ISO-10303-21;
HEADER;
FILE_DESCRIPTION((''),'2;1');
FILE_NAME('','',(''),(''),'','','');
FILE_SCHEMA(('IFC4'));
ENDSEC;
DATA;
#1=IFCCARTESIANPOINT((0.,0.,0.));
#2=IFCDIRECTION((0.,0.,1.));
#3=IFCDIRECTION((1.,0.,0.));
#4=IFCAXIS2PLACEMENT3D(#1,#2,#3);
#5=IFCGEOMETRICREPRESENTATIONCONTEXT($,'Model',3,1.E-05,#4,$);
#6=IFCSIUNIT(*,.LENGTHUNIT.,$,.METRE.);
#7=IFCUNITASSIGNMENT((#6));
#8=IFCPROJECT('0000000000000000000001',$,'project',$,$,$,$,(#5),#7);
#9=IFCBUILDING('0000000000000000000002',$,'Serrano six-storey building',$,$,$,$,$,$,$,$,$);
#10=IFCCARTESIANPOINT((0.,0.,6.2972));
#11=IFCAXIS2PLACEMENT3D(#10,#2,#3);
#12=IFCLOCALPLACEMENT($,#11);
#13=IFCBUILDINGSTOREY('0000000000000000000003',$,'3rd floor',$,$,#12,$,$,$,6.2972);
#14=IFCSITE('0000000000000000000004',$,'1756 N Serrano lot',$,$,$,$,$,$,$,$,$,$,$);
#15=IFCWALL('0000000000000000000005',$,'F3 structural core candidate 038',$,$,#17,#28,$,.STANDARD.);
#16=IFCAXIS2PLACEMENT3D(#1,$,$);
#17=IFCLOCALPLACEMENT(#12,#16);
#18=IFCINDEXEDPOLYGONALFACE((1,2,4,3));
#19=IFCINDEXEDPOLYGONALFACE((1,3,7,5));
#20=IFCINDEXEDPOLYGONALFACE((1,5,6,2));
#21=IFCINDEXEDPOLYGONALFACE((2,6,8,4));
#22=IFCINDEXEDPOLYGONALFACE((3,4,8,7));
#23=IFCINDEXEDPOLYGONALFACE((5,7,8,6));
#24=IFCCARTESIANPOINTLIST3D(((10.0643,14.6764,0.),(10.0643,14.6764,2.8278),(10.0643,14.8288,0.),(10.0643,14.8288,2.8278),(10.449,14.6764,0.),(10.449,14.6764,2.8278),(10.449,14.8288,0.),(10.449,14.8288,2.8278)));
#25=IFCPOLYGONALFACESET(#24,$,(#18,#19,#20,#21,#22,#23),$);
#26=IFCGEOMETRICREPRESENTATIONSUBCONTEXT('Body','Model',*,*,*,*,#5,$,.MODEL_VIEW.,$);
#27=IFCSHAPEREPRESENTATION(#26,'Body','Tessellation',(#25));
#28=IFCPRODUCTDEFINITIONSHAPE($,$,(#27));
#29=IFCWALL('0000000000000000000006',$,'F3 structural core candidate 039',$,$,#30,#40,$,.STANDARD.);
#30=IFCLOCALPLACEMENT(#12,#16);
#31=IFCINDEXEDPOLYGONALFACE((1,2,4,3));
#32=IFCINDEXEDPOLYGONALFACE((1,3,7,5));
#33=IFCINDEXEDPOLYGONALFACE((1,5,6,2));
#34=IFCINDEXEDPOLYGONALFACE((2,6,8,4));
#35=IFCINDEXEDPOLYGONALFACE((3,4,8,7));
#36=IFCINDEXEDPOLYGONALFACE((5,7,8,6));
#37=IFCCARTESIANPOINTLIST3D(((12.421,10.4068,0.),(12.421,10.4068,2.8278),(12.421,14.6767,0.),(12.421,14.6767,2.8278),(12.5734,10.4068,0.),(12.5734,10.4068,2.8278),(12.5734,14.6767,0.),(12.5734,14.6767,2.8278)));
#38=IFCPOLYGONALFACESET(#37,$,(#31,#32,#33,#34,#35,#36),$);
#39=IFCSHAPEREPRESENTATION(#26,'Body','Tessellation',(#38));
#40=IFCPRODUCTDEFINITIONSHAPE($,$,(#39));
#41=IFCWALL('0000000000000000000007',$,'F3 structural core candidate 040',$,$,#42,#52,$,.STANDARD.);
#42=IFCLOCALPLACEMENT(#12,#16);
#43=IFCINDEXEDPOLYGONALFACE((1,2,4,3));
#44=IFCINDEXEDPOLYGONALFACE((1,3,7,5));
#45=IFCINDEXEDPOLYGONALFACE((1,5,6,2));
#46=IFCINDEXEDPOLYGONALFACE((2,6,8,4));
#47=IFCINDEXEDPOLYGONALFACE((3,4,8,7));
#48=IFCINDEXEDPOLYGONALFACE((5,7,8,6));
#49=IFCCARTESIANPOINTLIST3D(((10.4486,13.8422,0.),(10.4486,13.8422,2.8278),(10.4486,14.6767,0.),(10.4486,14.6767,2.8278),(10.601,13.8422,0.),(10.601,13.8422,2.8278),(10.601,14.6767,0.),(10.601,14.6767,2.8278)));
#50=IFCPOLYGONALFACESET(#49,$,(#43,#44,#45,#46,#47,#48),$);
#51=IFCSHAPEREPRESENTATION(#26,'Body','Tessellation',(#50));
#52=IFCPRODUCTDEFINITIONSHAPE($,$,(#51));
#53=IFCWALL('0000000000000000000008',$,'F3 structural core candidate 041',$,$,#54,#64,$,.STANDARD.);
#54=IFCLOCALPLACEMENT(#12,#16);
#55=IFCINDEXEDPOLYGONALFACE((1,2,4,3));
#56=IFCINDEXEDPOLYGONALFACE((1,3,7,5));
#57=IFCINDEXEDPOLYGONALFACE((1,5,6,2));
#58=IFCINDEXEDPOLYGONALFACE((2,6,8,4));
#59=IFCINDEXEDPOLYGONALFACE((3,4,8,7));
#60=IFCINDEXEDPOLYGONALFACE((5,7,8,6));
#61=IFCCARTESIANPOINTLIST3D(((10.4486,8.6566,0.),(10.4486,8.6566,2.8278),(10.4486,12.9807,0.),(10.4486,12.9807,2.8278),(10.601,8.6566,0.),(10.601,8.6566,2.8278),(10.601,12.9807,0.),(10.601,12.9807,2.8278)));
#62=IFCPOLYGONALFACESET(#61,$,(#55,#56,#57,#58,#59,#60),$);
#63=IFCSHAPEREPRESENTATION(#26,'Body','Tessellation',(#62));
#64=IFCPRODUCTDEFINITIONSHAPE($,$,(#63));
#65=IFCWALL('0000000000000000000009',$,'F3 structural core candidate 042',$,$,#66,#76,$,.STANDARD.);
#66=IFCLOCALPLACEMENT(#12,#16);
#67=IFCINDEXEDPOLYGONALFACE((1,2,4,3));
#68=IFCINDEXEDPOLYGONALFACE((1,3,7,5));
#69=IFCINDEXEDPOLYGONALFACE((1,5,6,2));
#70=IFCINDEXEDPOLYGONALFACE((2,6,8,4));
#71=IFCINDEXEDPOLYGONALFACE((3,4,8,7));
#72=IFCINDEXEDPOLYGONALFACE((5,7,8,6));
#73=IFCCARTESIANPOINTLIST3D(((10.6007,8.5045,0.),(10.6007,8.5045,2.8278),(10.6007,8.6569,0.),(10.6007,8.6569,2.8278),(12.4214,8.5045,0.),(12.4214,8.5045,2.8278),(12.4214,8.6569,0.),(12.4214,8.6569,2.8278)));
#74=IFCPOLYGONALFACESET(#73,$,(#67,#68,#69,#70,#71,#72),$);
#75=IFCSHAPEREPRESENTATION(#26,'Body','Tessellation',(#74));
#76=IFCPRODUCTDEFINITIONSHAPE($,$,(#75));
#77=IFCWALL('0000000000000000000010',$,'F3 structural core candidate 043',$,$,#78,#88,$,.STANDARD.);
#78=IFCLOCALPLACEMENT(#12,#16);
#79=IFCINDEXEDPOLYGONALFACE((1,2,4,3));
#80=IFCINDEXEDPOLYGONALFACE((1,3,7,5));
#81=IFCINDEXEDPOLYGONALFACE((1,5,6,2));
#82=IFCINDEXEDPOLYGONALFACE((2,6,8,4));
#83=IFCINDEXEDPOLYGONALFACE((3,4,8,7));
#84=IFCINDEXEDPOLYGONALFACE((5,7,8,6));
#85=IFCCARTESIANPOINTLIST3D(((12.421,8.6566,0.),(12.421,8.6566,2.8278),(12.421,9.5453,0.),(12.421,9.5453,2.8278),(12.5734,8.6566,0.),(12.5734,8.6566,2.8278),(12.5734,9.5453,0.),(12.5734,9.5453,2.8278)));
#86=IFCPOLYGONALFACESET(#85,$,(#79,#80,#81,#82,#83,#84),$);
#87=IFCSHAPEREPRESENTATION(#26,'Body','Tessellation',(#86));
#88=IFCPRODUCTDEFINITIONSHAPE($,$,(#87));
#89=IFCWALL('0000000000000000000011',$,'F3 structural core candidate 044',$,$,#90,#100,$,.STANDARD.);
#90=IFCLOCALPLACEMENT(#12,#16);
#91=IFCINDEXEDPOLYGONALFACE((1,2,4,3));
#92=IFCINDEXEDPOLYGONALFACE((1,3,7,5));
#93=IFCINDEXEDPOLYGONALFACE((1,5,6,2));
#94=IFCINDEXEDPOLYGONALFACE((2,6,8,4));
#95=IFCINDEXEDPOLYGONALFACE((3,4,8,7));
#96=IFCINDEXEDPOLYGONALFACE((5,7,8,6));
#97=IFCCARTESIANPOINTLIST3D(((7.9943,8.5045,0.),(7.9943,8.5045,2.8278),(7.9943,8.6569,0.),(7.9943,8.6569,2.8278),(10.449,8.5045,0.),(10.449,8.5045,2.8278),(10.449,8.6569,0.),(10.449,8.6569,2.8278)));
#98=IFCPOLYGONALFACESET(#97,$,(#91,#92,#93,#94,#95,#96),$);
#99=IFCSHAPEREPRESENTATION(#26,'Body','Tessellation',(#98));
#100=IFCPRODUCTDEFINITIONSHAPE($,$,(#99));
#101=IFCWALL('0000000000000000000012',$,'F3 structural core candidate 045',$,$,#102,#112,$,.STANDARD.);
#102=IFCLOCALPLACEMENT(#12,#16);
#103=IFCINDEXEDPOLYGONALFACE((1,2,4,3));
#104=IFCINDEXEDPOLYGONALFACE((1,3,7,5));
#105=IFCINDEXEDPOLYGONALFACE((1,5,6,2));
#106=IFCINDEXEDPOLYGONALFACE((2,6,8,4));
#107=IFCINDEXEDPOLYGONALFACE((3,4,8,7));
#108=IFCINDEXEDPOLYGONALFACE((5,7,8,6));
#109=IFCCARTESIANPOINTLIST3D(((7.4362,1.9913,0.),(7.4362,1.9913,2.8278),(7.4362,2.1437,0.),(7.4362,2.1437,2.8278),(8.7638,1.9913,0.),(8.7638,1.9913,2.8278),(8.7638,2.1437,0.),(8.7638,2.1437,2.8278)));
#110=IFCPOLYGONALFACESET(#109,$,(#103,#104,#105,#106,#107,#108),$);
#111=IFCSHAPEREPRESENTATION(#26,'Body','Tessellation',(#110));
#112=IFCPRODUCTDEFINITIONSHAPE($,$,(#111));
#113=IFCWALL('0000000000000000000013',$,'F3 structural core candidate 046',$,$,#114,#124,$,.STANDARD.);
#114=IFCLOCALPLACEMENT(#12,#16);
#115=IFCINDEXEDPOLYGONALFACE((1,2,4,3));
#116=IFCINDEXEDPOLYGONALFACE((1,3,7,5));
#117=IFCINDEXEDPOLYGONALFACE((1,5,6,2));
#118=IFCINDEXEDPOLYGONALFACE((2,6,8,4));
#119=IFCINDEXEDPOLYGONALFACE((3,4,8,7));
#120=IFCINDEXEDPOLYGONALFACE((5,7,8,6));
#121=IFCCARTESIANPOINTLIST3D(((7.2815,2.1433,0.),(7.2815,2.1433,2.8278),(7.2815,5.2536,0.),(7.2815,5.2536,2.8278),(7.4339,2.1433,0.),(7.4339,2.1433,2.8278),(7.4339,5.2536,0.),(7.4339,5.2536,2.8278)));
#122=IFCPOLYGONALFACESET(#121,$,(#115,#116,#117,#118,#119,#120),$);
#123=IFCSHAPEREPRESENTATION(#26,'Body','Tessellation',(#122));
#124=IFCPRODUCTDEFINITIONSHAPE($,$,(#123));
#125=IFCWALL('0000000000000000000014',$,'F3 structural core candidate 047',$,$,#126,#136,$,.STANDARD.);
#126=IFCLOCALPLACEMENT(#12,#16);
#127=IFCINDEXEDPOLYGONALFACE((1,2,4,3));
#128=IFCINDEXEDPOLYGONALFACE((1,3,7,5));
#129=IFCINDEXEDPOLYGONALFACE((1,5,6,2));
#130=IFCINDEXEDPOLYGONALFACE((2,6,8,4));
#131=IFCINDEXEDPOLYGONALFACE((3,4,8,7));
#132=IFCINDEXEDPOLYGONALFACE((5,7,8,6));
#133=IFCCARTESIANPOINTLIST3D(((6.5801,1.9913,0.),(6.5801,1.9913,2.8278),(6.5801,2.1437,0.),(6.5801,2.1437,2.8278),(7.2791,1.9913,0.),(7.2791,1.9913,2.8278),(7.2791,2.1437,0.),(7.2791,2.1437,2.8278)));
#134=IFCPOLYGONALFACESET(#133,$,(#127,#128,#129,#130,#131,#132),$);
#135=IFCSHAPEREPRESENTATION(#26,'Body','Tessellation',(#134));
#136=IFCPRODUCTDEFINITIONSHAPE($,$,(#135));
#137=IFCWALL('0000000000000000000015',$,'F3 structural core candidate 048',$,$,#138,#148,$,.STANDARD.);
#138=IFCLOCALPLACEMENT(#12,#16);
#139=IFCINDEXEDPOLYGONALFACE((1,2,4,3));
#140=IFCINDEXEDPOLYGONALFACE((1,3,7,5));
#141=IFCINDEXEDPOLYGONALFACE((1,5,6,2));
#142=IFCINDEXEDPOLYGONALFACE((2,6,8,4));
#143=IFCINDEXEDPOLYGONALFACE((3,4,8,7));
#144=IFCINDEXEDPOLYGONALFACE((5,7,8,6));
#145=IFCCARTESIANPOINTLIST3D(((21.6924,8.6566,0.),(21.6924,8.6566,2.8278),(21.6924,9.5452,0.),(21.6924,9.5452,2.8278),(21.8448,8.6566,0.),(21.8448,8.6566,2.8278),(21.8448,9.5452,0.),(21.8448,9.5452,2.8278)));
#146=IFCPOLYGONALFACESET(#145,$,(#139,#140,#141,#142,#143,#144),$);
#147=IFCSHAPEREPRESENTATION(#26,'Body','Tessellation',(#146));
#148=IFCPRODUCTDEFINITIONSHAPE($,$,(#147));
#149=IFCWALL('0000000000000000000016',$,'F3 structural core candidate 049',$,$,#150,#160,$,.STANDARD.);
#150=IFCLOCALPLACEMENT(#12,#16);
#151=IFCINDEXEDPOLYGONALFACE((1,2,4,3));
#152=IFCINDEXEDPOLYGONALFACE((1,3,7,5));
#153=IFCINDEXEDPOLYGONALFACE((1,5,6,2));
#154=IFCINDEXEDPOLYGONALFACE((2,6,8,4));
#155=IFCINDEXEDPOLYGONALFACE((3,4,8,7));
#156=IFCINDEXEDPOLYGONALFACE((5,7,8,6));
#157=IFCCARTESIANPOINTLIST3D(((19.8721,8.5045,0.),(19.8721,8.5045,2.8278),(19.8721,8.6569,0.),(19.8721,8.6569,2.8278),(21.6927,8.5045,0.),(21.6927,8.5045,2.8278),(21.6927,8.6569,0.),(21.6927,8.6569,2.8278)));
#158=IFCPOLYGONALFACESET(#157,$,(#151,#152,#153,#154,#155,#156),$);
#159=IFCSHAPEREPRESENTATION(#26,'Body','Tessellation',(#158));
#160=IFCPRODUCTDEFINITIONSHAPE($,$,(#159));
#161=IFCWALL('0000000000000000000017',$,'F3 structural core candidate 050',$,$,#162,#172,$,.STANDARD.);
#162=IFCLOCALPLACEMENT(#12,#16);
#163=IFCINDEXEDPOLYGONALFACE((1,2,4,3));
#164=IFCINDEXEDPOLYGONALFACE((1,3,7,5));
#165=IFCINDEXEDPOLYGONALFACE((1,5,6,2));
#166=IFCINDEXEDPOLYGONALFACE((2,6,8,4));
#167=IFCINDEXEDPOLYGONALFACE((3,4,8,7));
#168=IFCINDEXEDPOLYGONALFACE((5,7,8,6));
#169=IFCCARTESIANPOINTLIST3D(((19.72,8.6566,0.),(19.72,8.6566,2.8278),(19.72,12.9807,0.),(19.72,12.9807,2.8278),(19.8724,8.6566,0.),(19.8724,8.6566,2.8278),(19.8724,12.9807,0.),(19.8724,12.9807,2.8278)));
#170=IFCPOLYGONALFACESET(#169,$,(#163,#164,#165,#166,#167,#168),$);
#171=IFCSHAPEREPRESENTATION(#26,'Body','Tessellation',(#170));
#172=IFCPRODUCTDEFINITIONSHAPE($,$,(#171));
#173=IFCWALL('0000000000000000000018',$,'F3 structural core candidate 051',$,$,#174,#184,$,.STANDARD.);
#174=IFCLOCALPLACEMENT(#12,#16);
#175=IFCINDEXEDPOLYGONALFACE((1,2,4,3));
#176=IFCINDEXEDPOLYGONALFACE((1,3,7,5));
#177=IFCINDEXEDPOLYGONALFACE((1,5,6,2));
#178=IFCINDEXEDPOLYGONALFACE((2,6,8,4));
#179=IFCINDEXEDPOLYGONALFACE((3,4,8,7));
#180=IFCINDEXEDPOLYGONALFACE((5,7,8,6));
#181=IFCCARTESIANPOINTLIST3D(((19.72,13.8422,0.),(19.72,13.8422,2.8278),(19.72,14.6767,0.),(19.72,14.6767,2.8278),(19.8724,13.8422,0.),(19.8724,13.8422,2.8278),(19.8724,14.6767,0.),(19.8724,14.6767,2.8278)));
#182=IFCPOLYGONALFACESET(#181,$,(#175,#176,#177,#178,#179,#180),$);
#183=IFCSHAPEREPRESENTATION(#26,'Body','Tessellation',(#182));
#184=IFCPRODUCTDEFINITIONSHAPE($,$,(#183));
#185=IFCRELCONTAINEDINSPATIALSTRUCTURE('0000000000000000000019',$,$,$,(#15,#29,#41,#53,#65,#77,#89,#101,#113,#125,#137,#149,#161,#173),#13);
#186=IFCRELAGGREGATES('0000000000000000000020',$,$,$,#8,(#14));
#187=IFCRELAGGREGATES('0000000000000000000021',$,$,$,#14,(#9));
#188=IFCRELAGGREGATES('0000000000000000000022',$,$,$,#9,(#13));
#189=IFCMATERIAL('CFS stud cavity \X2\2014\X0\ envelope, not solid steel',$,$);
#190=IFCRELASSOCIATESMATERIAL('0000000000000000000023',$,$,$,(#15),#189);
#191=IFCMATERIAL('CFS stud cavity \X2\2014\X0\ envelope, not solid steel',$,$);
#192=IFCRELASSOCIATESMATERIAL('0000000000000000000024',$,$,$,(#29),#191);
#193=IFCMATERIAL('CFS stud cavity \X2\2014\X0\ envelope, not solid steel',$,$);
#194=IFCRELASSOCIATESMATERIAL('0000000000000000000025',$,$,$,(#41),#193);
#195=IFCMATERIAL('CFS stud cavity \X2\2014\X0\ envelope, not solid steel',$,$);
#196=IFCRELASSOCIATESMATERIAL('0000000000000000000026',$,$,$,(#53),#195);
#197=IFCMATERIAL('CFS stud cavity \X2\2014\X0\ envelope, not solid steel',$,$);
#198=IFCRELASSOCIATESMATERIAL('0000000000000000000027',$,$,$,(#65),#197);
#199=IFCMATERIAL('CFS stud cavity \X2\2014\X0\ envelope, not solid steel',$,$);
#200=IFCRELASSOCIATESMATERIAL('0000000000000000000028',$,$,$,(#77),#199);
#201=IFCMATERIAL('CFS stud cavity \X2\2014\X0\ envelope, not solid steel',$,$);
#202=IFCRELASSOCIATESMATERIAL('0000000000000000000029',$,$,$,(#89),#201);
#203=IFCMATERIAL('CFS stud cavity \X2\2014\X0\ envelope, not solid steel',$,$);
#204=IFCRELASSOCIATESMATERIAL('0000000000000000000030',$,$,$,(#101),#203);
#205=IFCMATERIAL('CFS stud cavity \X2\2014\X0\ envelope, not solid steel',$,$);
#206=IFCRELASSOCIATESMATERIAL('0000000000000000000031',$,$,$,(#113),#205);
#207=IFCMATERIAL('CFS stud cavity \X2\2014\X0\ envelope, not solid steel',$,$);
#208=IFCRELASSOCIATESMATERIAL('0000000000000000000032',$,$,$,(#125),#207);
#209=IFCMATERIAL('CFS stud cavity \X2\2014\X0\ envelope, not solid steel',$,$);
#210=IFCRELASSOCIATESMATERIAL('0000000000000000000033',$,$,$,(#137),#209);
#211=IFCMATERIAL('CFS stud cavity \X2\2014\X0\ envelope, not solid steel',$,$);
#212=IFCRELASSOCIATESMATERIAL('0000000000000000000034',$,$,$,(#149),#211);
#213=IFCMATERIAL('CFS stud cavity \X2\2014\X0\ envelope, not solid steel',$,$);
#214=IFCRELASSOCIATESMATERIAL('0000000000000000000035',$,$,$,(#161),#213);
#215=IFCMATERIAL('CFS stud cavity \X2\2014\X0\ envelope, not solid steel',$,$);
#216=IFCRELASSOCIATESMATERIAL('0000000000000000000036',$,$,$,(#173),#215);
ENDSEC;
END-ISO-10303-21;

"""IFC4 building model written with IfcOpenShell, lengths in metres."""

from ifc_helpers import new_model, si_unit, frame, origin_with_axes, place, context, subcontext, project, spatial, polyline, outline, extrude, material, element, save


model = new_model("IFC4")

# Units and contexts
model_context = context("Model", 3, precision=1e-05, world=origin_with_axes())
body_context = subcontext(model_context, "Body", "Model", "MODEL_VIEW")
ifc_project = project(units=[si_unit("LENGTHUNIT", "METRE")], contexts=[model_context])

# Site, building, storey
site = spatial("IfcSite", under=ifc_project, Name="1756 N Serrano lot")
building = spatial("IfcBuilding", under=site, Name="Serrano six-storey building")
storey_placement = place(None, frame((0.0, 0.0, 6.2972), z_axis=(0.0, 0.0, 1.0), x_axis=(1.0, 0.0, 0.0)))
storey = spatial("IfcBuildingStorey", under=building, at=storey_placement, Name="3rd floor", Elevation=6.2972)

# Walls
ifc_material_1 = material(Name="CFS stud cavity — envelope, not solid steel")
wall_1_placement = place(storey_placement, frame((0.0, 0.0, -6.2972), z_axis=(0.0, 0.0, 1.0), x_axis=(1.0, 0.0, 0.0)))
element("IfcWall", 1, at=wall_1_placement, inside=storey, material=ifc_material_1, Name="F3 structural core candidate 038", PredefinedType="STANDARD", context=body_context, shape_type="SweptSolid", body=[
    extrude(outline(polyline([(10.449, 14.8288), (10.449, 14.6764), (10.0643, 14.6764), (10.0643, 14.8288), (10.449, 14.8288)])), frame((0.0, 0.0, 6.2972)), (0.0, 0.0, 1.0), 2.8278),
])
ifc_material_2 = material(Name="CFS stud cavity — envelope, not solid steel")
wall_2_placement = place(storey_placement, frame((0.0, 0.0, -6.2972), z_axis=(0.0, 0.0, 1.0), x_axis=(1.0, 0.0, 0.0)))
element("IfcWall", 2, at=wall_2_placement, inside=storey, material=ifc_material_2, Name="F3 structural core candidate 039", PredefinedType="STANDARD", context=body_context, shape_type="SweptSolid", body=[
    extrude(outline(polyline([(12.5734, 10.4068), (12.421, 10.4068), (12.421, 14.6767), (12.5734, 14.6767), (12.5734, 10.4068)])), frame((0.0, 0.0, 6.2972)), (0.0, 0.0, 1.0), 2.8278),
])
ifc_material_3 = material(Name="CFS stud cavity — envelope, not solid steel")
wall_3_placement = place(storey_placement, frame((0.0, 0.0, -6.2972), z_axis=(0.0, 0.0, 1.0), x_axis=(1.0, 0.0, 0.0)))
element("IfcWall", 3, at=wall_3_placement, inside=storey, material=ifc_material_3, Name="F3 structural core candidate 040", PredefinedType="STANDARD", context=body_context, shape_type="SweptSolid", body=[
    extrude(outline(polyline([(10.601, 13.8422), (10.4486, 13.8422), (10.4486, 14.6767), (10.601, 14.6767), (10.601, 13.8422)])), frame((0.0, 0.0, 6.2972)), (0.0, 0.0, 1.0), 2.8278),
])
ifc_material_4 = material(Name="CFS stud cavity — envelope, not solid steel")
wall_4_placement = place(storey_placement, frame((0.0, 0.0, -6.2972), z_axis=(0.0, 0.0, 1.0), x_axis=(1.0, 0.0, 0.0)))
element("IfcWall", 4, at=wall_4_placement, inside=storey, material=ifc_material_4, Name="F3 structural core candidate 041", PredefinedType="STANDARD", context=body_context, shape_type="SweptSolid", body=[
    extrude(outline(polyline([(10.601, 8.6566), (10.4486, 8.6566), (10.4486, 12.9807), (10.601, 12.9807), (10.601, 8.6566)])), frame((0.0, 0.0, 6.2972)), (0.0, 0.0, 1.0), 2.8278),
])
ifc_material_5 = material(Name="CFS stud cavity — envelope, not solid steel")
wall_5_placement = place(storey_placement, frame((0.0, 0.0, -6.2972), z_axis=(0.0, 0.0, 1.0), x_axis=(1.0, 0.0, 0.0)))
element("IfcWall", 5, at=wall_5_placement, inside=storey, material=ifc_material_5, Name="F3 structural core candidate 042", PredefinedType="STANDARD", context=body_context, shape_type="SweptSolid", body=[
    extrude(outline(polyline([(12.4214, 8.6569), (12.4214, 8.5045), (10.6007, 8.5045), (10.6007, 8.6569), (12.4214, 8.6569)])), frame((0.0, 0.0, 6.2972)), (0.0, 0.0, 1.0), 2.8278),
])
ifc_material_6 = material(Name="CFS stud cavity — envelope, not solid steel")
wall_6_placement = place(storey_placement, frame((0.0, 0.0, -6.2972), z_axis=(0.0, 0.0, 1.0), x_axis=(1.0, 0.0, 0.0)))
element("IfcWall", 6, at=wall_6_placement, inside=storey, material=ifc_material_6, Name="F3 structural core candidate 043", PredefinedType="STANDARD", context=body_context, shape_type="SweptSolid", body=[
    extrude(outline(polyline([(12.5734, 8.6566), (12.421, 8.6566), (12.421, 9.5453), (12.5734, 9.5453), (12.5734, 8.6566)])), frame((0.0, 0.0, 6.2972)), (0.0, 0.0, 1.0), 2.8278),
])
ifc_material_7 = material(Name="CFS stud cavity — envelope, not solid steel")
wall_7_placement = place(storey_placement, frame((0.0, 0.0, -6.2972), z_axis=(0.0, 0.0, 1.0), x_axis=(1.0, 0.0, 0.0)))
element("IfcWall", 7, at=wall_7_placement, inside=storey, material=ifc_material_7, Name="F3 structural core candidate 044", PredefinedType="STANDARD", context=body_context, shape_type="SweptSolid", body=[
    extrude(outline(polyline([(10.449, 8.6569), (10.449, 8.5045), (7.9943, 8.5045), (7.9943, 8.6569), (10.449, 8.6569)])), frame((0.0, 0.0, 6.2972)), (0.0, 0.0, 1.0), 2.8278),
])
ifc_material_8 = material(Name="CFS stud cavity — envelope, not solid steel")
wall_8_placement = place(storey_placement, frame((0.0, 0.0, -6.2972), z_axis=(0.0, 0.0, 1.0), x_axis=(1.0, 0.0, 0.0)))
element("IfcWall", 8, at=wall_8_placement, inside=storey, material=ifc_material_8, Name="F3 structural core candidate 045", PredefinedType="STANDARD", context=body_context, shape_type="SweptSolid", body=[
    extrude(outline(polyline([(8.7638, 2.1437), (8.7638, 1.9913), (7.4362, 1.9913), (7.4362, 2.1437), (8.7638, 2.1437)])), frame((0.0, 0.0, 6.2972)), (0.0, 0.0, 1.0), 2.8278),
])
ifc_material_9 = material(Name="CFS stud cavity — envelope, not solid steel")
wall_9_placement = place(storey_placement, frame((0.0, 0.0, -6.2972), z_axis=(0.0, 0.0, 1.0), x_axis=(1.0, 0.0, 0.0)))
element("IfcWall", 9, at=wall_9_placement, inside=storey, material=ifc_material_9, Name="F3 structural core candidate 046", PredefinedType="STANDARD", context=body_context, shape_type="SweptSolid", body=[
    extrude(outline(polyline([(7.4339, 2.1433), (7.2815, 2.1433), (7.2815, 5.2536), (7.4339, 5.2536), (7.4339, 2.1433)])), frame((0.0, 0.0, 6.2972)), (0.0, 0.0, 1.0), 2.8278),
])
ifc_material_10 = material(Name="CFS stud cavity — envelope, not solid steel")
wall_10_placement = place(storey_placement, frame((0.0, 0.0, -6.2972), z_axis=(0.0, 0.0, 1.0), x_axis=(1.0, 0.0, 0.0)))
element("IfcWall", 10, at=wall_10_placement, inside=storey, material=ifc_material_10, Name="F3 structural core candidate 047", PredefinedType="STANDARD", context=body_context, shape_type="SweptSolid", body=[
    extrude(outline(polyline([(7.2791, 2.1437), (7.2791, 1.9913), (6.5801, 1.9913), (6.5801, 2.1437), (7.2791, 2.1437)])), frame((0.0, 0.0, 6.2972)), (0.0, 0.0, 1.0), 2.8278),
])
ifc_material_11 = material(Name="CFS stud cavity — envelope, not solid steel")
wall_11_placement = place(storey_placement, frame((0.0, 0.0, -6.2972), z_axis=(0.0, 0.0, 1.0), x_axis=(1.0, 0.0, 0.0)))
element("IfcWall", 11, at=wall_11_placement, inside=storey, material=ifc_material_11, Name="F3 structural core candidate 048", PredefinedType="STANDARD", context=body_context, shape_type="SweptSolid", body=[
    extrude(outline(polyline([(21.8448, 8.6566), (21.6924, 8.6566), (21.6924, 9.5452), (21.8448, 9.5452), (21.8448, 8.6566)])), frame((0.0, 0.0, 6.2972)), (0.0, 0.0, 1.0), 2.8278),
])
ifc_material_12 = material(Name="CFS stud cavity — envelope, not solid steel")
wall_12_placement = place(storey_placement, frame((0.0, 0.0, -6.2972), z_axis=(0.0, 0.0, 1.0), x_axis=(1.0, 0.0, 0.0)))
element("IfcWall", 12, at=wall_12_placement, inside=storey, material=ifc_material_12, Name="F3 structural core candidate 049", PredefinedType="STANDARD", context=body_context, shape_type="SweptSolid", body=[
    extrude(outline(polyline([(21.6927, 8.6569), (21.6927, 8.5045), (19.8721, 8.5045), (19.8721, 8.6569), (21.6927, 8.6569)])), frame((0.0, 0.0, 6.2972)), (0.0, 0.0, 1.0), 2.8278),
])
ifc_material_13 = material(Name="CFS stud cavity — envelope, not solid steel")
wall_13_placement = place(storey_placement, frame((0.0, 0.0, -6.2972), z_axis=(0.0, 0.0, 1.0), x_axis=(1.0, 0.0, 0.0)))
element("IfcWall", 13, at=wall_13_placement, inside=storey, material=ifc_material_13, Name="F3 structural core candidate 050", PredefinedType="STANDARD", context=body_context, shape_type="SweptSolid", body=[
    extrude(outline(polyline([(19.8724, 8.6566), (19.72, 8.6566), (19.72, 12.9807), (19.8724, 12.9807), (19.8724, 8.6566)])), frame((0.0, 0.0, 6.2972)), (0.0, 0.0, 1.0), 2.8278),
])
ifc_material_14 = material(Name="CFS stud cavity — envelope, not solid steel")
wall_14_placement = place(storey_placement, frame((0.0, 0.0, -6.2972), z_axis=(0.0, 0.0, 1.0), x_axis=(1.0, 0.0, 0.0)))
element("IfcWall", 14, at=wall_14_placement, inside=storey, material=ifc_material_14, Name="F3 structural core candidate 051", PredefinedType="STANDARD", context=body_context, shape_type="SweptSolid", body=[
    extrude(outline(polyline([(19.8724, 13.8422), (19.72, 13.8422), (19.72, 14.6767), (19.8724, 14.6767), (19.8724, 13.8422)])), frame((0.0, 0.0, 6.2972)), (0.0, 0.0, 1.0), 2.8278),
])

save(model, "model.ifc")
